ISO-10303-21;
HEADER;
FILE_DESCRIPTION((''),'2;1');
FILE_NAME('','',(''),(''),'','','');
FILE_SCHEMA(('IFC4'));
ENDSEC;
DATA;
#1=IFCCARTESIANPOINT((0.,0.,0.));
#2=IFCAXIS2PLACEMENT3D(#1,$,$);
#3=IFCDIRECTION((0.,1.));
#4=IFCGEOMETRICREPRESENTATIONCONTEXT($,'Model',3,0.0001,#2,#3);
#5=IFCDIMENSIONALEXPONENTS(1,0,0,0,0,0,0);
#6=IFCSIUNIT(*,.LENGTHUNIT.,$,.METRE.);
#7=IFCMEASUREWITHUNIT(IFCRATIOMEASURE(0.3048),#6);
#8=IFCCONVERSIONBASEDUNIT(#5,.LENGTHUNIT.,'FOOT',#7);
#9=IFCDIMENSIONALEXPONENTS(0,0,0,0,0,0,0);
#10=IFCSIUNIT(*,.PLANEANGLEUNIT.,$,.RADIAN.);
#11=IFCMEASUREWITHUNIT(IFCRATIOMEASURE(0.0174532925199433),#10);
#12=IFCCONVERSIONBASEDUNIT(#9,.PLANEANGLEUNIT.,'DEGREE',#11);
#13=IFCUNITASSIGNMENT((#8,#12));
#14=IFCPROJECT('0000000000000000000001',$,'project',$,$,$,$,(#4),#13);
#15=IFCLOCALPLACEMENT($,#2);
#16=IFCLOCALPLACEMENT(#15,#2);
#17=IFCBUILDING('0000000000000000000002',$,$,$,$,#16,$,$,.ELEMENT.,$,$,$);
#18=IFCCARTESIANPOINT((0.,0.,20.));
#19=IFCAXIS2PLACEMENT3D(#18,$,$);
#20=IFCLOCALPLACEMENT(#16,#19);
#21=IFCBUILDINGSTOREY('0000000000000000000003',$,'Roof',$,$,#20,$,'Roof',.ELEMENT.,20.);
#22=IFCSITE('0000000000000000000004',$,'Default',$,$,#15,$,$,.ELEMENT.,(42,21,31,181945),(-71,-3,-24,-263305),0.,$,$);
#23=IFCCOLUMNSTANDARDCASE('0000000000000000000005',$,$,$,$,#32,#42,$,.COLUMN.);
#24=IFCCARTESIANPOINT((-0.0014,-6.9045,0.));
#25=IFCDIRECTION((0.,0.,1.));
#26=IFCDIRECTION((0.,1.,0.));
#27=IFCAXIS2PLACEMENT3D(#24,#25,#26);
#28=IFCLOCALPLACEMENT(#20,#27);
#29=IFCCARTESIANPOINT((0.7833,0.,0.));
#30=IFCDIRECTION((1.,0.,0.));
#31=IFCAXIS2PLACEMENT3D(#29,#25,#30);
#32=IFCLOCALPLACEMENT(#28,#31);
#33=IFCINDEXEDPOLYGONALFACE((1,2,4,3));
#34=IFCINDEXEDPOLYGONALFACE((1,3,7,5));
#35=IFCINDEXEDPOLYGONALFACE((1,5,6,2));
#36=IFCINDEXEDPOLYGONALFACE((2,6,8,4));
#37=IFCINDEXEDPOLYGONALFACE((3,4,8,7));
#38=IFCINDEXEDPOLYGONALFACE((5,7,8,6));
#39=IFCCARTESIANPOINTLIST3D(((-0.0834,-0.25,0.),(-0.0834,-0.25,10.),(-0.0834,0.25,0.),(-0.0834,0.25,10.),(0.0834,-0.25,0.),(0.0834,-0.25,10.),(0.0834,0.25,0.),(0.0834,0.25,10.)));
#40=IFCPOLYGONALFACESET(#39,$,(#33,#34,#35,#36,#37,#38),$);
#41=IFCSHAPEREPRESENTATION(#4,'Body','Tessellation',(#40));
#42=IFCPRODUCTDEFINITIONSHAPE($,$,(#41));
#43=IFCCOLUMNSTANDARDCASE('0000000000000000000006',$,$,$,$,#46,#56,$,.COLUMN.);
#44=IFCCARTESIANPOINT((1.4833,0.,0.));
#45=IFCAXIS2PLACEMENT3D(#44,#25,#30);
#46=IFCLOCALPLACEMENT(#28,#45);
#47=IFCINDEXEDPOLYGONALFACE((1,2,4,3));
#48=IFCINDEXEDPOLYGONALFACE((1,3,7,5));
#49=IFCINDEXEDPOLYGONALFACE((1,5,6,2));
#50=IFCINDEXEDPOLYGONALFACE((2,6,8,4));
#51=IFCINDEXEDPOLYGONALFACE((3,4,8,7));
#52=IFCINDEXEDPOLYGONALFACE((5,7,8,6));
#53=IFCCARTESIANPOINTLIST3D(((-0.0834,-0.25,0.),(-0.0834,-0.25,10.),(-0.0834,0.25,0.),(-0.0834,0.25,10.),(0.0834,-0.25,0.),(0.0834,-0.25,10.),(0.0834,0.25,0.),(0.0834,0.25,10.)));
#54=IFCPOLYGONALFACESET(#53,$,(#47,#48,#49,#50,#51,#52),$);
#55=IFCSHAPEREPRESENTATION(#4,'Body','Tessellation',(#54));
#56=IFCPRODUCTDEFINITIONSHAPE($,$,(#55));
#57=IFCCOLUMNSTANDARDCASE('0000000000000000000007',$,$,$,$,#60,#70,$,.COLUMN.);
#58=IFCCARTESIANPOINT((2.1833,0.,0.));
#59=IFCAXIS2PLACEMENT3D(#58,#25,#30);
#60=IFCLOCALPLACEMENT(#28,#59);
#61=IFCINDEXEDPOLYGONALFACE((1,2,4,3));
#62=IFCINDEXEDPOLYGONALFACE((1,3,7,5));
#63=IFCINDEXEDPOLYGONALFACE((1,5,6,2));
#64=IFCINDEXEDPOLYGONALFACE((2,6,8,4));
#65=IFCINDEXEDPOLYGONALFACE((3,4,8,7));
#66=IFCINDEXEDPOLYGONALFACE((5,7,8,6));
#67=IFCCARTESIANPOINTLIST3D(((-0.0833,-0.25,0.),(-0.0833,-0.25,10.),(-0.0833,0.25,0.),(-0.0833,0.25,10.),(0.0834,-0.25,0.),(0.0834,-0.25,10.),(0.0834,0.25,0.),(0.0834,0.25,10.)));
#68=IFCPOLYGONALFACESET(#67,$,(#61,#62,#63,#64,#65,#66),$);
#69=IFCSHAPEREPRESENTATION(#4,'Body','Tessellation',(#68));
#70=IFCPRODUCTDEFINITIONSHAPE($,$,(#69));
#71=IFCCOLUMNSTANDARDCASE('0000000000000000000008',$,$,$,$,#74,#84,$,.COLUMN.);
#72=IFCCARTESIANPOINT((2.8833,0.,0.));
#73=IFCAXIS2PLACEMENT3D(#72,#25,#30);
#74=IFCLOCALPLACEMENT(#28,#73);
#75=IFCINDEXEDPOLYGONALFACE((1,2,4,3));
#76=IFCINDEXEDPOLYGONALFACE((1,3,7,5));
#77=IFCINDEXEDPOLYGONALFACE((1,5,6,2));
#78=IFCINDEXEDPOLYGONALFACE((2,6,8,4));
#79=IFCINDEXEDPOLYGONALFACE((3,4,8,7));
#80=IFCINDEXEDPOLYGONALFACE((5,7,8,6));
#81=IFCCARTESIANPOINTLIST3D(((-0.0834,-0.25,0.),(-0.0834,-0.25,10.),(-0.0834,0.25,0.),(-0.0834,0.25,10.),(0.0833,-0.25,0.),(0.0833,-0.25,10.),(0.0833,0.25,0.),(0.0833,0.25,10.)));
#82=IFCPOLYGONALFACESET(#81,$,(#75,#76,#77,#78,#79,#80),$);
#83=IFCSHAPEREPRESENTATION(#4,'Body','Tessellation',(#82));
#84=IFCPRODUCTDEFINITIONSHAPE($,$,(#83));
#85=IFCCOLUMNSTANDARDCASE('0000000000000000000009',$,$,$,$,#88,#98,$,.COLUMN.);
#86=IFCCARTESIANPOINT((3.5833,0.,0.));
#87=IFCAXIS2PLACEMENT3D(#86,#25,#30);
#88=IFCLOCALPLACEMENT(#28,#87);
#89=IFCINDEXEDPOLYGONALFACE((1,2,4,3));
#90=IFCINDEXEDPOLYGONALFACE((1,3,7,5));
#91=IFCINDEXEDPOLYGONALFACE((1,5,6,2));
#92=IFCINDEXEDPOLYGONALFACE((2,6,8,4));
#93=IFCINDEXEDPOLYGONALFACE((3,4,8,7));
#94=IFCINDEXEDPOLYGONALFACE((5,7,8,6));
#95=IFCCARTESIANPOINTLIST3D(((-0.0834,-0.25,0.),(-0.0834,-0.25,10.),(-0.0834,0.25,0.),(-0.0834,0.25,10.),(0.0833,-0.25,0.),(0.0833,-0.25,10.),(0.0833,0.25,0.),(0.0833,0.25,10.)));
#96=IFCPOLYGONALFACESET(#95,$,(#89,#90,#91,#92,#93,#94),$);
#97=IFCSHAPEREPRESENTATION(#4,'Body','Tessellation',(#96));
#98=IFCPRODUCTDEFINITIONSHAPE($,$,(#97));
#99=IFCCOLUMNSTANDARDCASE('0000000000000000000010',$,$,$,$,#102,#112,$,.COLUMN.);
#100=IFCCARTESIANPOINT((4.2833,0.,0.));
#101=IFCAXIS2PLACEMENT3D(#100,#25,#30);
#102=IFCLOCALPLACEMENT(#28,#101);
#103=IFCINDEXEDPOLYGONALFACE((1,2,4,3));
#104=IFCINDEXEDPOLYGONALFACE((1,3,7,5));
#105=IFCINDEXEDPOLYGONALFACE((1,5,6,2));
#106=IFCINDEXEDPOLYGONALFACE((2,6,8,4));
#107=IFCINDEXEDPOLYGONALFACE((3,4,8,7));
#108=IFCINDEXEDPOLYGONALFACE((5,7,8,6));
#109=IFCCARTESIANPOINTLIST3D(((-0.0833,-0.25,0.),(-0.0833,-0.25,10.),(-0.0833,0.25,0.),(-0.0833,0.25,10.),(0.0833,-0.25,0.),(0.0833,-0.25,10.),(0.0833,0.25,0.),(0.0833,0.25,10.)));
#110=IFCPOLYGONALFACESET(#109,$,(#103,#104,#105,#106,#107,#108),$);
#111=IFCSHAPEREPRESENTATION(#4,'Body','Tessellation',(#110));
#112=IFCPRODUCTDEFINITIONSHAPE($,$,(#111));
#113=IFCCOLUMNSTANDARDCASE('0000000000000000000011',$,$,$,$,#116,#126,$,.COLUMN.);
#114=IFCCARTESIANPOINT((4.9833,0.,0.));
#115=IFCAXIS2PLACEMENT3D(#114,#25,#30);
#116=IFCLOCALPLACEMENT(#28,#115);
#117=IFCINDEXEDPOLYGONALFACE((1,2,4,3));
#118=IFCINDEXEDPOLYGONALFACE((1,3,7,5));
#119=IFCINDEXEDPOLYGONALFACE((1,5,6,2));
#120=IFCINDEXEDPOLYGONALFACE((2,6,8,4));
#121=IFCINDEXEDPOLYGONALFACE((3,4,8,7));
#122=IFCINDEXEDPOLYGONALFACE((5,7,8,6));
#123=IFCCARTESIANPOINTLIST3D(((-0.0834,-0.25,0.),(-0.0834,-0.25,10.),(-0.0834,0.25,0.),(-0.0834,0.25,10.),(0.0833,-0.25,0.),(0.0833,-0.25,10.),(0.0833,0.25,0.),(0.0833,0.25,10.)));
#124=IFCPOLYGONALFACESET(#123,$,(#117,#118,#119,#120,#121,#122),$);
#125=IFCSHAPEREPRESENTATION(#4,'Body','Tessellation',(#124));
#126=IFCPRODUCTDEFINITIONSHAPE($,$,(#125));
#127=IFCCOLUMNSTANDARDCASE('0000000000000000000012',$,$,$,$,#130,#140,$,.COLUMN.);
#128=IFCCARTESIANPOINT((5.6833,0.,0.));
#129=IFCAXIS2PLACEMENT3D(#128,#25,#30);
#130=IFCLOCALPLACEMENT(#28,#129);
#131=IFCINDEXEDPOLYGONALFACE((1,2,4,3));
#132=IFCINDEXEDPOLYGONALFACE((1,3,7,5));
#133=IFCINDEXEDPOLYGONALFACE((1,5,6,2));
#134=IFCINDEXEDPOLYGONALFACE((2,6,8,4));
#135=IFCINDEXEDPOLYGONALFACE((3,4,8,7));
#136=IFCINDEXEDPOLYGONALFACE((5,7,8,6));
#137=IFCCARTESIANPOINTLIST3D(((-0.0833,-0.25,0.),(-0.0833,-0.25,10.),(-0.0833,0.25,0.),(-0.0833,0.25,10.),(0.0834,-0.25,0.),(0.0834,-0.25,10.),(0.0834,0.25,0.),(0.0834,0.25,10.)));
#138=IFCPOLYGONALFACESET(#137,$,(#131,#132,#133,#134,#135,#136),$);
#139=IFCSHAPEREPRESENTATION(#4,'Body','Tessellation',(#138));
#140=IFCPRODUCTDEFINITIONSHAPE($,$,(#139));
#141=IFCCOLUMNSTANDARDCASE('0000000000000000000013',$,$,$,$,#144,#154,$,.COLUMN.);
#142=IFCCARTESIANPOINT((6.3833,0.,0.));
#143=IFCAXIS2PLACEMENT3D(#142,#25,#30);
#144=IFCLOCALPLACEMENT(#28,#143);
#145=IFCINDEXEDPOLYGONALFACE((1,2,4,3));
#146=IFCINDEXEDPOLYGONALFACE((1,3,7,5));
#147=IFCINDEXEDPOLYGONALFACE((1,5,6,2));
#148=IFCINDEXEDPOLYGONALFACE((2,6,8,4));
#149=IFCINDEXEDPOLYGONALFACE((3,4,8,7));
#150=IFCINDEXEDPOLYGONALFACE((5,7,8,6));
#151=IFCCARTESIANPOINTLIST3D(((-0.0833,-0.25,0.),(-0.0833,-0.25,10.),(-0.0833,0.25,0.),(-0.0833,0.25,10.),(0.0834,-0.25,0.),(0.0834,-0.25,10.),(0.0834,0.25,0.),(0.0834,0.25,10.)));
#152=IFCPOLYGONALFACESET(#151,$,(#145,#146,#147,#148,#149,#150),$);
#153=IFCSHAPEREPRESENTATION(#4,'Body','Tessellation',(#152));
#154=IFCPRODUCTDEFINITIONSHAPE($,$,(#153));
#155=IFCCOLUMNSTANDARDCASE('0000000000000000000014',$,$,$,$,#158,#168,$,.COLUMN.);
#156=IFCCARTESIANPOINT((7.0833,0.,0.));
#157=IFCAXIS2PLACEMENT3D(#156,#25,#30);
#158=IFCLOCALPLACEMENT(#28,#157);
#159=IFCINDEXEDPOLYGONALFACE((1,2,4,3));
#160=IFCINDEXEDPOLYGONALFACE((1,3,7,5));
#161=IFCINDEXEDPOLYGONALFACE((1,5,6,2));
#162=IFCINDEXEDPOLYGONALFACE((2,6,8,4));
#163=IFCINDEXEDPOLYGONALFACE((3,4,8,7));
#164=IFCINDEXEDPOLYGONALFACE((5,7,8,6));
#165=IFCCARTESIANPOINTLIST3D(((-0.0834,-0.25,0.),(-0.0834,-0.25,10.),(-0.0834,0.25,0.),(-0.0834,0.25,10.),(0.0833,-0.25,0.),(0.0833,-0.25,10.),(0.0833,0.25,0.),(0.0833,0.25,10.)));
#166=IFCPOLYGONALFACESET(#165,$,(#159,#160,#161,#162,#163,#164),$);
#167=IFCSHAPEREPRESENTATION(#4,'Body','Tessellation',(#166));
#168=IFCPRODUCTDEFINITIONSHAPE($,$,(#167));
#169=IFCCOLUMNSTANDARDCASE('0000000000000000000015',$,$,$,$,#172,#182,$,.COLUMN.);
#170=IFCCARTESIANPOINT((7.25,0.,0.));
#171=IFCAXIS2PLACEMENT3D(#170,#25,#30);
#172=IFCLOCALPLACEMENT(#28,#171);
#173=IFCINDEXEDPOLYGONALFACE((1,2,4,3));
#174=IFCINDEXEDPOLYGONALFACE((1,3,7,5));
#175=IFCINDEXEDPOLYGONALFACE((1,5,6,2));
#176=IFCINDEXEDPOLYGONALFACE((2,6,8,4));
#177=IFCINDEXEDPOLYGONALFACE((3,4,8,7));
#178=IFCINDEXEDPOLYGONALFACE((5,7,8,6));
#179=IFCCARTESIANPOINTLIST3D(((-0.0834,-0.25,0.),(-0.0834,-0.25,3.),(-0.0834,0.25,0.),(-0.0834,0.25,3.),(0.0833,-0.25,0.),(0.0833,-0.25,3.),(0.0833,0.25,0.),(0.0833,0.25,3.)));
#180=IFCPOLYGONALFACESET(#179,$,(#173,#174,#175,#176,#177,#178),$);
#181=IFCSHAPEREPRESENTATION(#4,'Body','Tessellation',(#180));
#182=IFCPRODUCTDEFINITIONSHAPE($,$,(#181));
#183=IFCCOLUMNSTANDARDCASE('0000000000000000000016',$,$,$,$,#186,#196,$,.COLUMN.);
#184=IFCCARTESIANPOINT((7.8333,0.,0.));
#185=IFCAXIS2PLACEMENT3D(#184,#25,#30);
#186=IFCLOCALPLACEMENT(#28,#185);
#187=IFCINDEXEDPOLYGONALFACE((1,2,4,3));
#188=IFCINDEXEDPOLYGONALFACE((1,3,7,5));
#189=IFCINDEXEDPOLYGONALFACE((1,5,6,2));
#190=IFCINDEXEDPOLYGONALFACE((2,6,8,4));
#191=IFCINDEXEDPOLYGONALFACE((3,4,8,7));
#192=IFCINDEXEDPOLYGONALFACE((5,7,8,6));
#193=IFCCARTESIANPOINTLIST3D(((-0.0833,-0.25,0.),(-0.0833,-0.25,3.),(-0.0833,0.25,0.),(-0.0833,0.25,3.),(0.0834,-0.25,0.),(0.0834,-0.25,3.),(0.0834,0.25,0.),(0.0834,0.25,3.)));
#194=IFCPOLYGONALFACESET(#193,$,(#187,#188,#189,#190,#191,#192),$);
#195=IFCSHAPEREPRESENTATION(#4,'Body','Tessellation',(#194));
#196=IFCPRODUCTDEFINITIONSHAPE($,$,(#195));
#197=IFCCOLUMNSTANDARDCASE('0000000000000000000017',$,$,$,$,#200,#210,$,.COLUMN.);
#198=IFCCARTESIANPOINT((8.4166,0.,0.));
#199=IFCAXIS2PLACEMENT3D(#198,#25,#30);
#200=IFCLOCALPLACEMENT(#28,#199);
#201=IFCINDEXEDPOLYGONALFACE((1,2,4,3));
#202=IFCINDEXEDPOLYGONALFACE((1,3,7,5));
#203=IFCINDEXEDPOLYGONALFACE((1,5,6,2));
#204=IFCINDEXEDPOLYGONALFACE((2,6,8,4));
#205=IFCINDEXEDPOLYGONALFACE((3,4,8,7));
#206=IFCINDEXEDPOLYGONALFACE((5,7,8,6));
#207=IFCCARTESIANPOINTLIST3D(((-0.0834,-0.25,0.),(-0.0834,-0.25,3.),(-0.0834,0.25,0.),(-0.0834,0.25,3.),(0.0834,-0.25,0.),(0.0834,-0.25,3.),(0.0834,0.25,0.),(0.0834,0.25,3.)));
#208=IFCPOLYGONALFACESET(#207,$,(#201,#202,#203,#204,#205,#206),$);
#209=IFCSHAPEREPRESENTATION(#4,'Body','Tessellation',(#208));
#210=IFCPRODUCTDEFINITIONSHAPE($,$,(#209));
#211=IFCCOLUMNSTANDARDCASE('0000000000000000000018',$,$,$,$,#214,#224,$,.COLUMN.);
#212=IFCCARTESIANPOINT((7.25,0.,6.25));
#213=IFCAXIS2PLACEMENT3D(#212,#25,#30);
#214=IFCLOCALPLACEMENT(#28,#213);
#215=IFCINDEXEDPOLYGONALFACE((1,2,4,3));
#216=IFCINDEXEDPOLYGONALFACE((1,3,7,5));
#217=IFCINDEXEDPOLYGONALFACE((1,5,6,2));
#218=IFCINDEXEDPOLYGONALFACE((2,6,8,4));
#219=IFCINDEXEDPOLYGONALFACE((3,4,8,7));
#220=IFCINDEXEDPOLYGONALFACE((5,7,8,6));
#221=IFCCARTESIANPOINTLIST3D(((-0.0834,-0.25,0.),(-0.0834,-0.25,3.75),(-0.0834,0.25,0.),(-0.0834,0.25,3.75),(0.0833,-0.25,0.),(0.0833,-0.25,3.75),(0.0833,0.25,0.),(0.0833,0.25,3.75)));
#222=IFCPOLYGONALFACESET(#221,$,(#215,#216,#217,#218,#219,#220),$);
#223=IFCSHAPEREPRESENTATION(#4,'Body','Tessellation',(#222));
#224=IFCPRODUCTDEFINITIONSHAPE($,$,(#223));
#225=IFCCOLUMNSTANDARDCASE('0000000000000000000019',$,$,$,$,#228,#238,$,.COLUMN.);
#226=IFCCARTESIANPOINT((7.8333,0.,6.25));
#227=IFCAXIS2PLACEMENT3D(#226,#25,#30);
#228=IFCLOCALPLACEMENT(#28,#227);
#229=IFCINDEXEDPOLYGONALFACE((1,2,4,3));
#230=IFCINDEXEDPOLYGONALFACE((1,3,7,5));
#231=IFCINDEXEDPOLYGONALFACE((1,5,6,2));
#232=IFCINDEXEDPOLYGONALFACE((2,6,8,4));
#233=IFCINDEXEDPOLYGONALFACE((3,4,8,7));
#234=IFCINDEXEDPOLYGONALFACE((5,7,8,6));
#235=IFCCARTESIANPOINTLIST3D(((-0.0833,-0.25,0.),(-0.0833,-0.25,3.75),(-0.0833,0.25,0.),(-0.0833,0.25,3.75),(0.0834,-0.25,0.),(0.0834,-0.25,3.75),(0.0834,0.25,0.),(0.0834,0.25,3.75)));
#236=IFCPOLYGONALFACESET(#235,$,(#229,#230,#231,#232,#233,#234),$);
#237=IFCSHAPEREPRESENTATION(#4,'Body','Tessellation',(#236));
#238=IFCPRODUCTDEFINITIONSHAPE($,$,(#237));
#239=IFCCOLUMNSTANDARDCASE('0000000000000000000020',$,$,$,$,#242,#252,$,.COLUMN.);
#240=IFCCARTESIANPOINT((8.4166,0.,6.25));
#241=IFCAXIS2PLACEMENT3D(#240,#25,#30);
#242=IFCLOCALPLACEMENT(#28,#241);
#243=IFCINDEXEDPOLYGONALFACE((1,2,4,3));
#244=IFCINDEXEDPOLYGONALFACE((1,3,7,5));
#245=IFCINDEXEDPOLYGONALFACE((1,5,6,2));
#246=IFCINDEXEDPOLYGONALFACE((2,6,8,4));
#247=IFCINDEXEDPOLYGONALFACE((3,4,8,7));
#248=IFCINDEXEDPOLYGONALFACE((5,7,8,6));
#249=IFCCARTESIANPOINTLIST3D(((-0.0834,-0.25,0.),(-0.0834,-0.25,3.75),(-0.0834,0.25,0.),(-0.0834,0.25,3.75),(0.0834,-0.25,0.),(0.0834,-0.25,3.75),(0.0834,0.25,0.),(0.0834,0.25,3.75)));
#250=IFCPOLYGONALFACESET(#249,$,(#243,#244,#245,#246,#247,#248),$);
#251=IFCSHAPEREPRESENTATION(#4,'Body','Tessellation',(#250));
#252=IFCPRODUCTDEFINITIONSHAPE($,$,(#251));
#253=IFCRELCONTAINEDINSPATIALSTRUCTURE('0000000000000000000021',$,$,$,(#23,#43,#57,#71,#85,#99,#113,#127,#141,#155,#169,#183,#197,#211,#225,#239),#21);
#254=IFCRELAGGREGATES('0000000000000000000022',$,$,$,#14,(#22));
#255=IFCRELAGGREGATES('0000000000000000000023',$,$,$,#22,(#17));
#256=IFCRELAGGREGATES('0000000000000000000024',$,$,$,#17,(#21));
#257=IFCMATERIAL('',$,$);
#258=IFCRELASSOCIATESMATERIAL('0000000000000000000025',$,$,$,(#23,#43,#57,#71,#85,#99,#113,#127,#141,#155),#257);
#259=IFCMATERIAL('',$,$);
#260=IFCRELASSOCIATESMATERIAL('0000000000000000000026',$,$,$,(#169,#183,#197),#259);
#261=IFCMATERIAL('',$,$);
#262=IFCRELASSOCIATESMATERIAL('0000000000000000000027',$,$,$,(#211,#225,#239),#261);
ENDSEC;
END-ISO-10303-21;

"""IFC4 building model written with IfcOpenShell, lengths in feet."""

from ifc_helpers import new_model, entity, si_unit, converted_unit, direction, frame, origin, place, context, project, spatial, rectangle, extrude, material, element, save


model = new_model("IFC4")

# Units and contexts
model_context = context("Model", 3, precision=0.0001, world=origin(), true_north=direction((0.0, 1.0)))
ifc_project = project(units=[converted_unit("LENGTHUNIT", "FOOT", entity("IfcRatioMeasure", 0.3048), si_unit("LENGTHUNIT", "METRE"), dimensions=[1, 0, 0, 0, 0, 0, 0]), converted_unit("PLANEANGLEUNIT", "DEGREE", entity("IfcRatioMeasure", 0.0174532925199433), si_unit("PLANEANGLEUNIT", "RADIAN"), dimensions=[0, 0, 0, 0, 0, 0, 0])], contexts=[model_context])

# Site, building, storey
site_placement = place(None, origin())
site = spatial("IfcSite", under=ifc_project, at=site_placement, Name="Default", CompositionType="ELEMENT", RefLatitude=(42, 21, 31, 181945), RefLongitude=(-71, -3, -24, -263305), RefElevation=0.0)
building_placement = place(site_placement, origin())
building = spatial("IfcBuilding", under=site, at=building_placement, CompositionType="ELEMENT")
storey_placement = place(building_placement, frame((0.0, 0.0, 20.0)))
storey = spatial("IfcBuildingStorey", under=building, at=storey_placement, Name="Roof", LongName="Roof", CompositionType="ELEMENT", Elevation=20.0)

# Columns
ifc_material_1 = material(Name="")
wall_placement = place(storey_placement, frame((-0.0014, -6.9045, 0.0), z_axis=(0.0, 0.0, 1.0), x_axis=(0.0, 1.0, 0.0)))
for number, where, z_axis, x_axis in (
    (1, (0.7833, 0.0, 0.0), (0.0, 0.0, 1.0), (1.0, 0.0, 0.0)),
    (2, (1.4833, 0.0, 0.0), (0.0, 0.0, 1.0), (1.0, 0.0, 0.0)),
    (3, (2.1833, 0.0, 0.0), (0.0, 0.0, 1.0), (1.0, 0.0, 0.0)),
    (4, (2.8833, 0.0, 0.0), (0.0, 0.0, 1.0), (1.0, 0.0, 0.0)),
    (5, (3.5833, 0.0, 0.0), (0.0, 0.0, 1.0), (1.0, 0.0, 0.0)),
    (6, (4.2833, 0.0, 0.0), (0.0, 0.0, 1.0), (1.0, 0.0, 0.0)),
    (7, (4.9833, 0.0, 0.0), (0.0, 0.0, 1.0), (1.0, 0.0, 0.0)),
    (8, (5.6833, 0.0, 0.0), (0.0, 0.0, 1.0), (1.0, 0.0, 0.0)),
    (9, (6.3833, 0.0, 0.0), (0.0, 0.0, 1.0), (1.0, 0.0, 0.0)),
    (10, (7.0833, 0.0, 0.0), (0.0, 0.0, 1.0), (1.0, 0.0, 0.0)),
):
    element("IfcColumnStandardCase", number, at=place(wall_placement, frame(where, z_axis=z_axis, x_axis=x_axis)), inside=storey, material=ifc_material_1, PredefinedType="COLUMN", context=model_context, shape_type="SweptSolid", body=[
        extrude(rectangle(XDim=0.1667, YDim=0.5), origin(), (0.0, 0.0, 1.0), 10.0),
    ])
ifc_material_2 = material(Name="")
for number, where, z_axis, x_axis in (
    (11, (7.25, 0.0, 0.0), (0.0, 0.0, 1.0), (1.0, 0.0, 0.0)),
    (12, (7.8333, 0.0, 0.0), (0.0, 0.0, 1.0), (1.0, 0.0, 0.0)),
    (13, (8.4166, 0.0, 0.0), (0.0, 0.0, 1.0), (1.0, 0.0, 0.0)),
):
    element("IfcColumnStandardCase", number, at=place(wall_placement, frame(where, z_axis=z_axis, x_axis=x_axis)), inside=storey, material=ifc_material_2, PredefinedType="COLUMN", context=model_context, shape_type="SweptSolid", body=[
        extrude(rectangle(XDim=0.1667, YDim=0.5), origin(), (0.0, 0.0, 1.0), 3.0),
    ])
ifc_material_3 = material(Name="")
for number, where, z_axis, x_axis in (
    (14, (7.25, 0.0, 6.25), (0.0, 0.0, 1.0), (1.0, 0.0, 0.0)),
    (15, (7.8333, 0.0, 6.25), (0.0, 0.0, 1.0), (1.0, 0.0, 0.0)),
    (16, (8.4166, 0.0, 6.25), (0.0, 0.0, 1.0), (1.0, 0.0, 0.0)),
):
    element("IfcColumnStandardCase", number, at=place(wall_placement, frame(where, z_axis=z_axis, x_axis=x_axis)), inside=storey, material=ifc_material_3, PredefinedType="COLUMN", context=model_context, shape_type="SweptSolid", body=[
        extrude(rectangle(XDim=0.1667, YDim=0.5), origin(), (0.0, 0.0, 1.0), 3.75),
    ])

save(model, "model.ifc")
